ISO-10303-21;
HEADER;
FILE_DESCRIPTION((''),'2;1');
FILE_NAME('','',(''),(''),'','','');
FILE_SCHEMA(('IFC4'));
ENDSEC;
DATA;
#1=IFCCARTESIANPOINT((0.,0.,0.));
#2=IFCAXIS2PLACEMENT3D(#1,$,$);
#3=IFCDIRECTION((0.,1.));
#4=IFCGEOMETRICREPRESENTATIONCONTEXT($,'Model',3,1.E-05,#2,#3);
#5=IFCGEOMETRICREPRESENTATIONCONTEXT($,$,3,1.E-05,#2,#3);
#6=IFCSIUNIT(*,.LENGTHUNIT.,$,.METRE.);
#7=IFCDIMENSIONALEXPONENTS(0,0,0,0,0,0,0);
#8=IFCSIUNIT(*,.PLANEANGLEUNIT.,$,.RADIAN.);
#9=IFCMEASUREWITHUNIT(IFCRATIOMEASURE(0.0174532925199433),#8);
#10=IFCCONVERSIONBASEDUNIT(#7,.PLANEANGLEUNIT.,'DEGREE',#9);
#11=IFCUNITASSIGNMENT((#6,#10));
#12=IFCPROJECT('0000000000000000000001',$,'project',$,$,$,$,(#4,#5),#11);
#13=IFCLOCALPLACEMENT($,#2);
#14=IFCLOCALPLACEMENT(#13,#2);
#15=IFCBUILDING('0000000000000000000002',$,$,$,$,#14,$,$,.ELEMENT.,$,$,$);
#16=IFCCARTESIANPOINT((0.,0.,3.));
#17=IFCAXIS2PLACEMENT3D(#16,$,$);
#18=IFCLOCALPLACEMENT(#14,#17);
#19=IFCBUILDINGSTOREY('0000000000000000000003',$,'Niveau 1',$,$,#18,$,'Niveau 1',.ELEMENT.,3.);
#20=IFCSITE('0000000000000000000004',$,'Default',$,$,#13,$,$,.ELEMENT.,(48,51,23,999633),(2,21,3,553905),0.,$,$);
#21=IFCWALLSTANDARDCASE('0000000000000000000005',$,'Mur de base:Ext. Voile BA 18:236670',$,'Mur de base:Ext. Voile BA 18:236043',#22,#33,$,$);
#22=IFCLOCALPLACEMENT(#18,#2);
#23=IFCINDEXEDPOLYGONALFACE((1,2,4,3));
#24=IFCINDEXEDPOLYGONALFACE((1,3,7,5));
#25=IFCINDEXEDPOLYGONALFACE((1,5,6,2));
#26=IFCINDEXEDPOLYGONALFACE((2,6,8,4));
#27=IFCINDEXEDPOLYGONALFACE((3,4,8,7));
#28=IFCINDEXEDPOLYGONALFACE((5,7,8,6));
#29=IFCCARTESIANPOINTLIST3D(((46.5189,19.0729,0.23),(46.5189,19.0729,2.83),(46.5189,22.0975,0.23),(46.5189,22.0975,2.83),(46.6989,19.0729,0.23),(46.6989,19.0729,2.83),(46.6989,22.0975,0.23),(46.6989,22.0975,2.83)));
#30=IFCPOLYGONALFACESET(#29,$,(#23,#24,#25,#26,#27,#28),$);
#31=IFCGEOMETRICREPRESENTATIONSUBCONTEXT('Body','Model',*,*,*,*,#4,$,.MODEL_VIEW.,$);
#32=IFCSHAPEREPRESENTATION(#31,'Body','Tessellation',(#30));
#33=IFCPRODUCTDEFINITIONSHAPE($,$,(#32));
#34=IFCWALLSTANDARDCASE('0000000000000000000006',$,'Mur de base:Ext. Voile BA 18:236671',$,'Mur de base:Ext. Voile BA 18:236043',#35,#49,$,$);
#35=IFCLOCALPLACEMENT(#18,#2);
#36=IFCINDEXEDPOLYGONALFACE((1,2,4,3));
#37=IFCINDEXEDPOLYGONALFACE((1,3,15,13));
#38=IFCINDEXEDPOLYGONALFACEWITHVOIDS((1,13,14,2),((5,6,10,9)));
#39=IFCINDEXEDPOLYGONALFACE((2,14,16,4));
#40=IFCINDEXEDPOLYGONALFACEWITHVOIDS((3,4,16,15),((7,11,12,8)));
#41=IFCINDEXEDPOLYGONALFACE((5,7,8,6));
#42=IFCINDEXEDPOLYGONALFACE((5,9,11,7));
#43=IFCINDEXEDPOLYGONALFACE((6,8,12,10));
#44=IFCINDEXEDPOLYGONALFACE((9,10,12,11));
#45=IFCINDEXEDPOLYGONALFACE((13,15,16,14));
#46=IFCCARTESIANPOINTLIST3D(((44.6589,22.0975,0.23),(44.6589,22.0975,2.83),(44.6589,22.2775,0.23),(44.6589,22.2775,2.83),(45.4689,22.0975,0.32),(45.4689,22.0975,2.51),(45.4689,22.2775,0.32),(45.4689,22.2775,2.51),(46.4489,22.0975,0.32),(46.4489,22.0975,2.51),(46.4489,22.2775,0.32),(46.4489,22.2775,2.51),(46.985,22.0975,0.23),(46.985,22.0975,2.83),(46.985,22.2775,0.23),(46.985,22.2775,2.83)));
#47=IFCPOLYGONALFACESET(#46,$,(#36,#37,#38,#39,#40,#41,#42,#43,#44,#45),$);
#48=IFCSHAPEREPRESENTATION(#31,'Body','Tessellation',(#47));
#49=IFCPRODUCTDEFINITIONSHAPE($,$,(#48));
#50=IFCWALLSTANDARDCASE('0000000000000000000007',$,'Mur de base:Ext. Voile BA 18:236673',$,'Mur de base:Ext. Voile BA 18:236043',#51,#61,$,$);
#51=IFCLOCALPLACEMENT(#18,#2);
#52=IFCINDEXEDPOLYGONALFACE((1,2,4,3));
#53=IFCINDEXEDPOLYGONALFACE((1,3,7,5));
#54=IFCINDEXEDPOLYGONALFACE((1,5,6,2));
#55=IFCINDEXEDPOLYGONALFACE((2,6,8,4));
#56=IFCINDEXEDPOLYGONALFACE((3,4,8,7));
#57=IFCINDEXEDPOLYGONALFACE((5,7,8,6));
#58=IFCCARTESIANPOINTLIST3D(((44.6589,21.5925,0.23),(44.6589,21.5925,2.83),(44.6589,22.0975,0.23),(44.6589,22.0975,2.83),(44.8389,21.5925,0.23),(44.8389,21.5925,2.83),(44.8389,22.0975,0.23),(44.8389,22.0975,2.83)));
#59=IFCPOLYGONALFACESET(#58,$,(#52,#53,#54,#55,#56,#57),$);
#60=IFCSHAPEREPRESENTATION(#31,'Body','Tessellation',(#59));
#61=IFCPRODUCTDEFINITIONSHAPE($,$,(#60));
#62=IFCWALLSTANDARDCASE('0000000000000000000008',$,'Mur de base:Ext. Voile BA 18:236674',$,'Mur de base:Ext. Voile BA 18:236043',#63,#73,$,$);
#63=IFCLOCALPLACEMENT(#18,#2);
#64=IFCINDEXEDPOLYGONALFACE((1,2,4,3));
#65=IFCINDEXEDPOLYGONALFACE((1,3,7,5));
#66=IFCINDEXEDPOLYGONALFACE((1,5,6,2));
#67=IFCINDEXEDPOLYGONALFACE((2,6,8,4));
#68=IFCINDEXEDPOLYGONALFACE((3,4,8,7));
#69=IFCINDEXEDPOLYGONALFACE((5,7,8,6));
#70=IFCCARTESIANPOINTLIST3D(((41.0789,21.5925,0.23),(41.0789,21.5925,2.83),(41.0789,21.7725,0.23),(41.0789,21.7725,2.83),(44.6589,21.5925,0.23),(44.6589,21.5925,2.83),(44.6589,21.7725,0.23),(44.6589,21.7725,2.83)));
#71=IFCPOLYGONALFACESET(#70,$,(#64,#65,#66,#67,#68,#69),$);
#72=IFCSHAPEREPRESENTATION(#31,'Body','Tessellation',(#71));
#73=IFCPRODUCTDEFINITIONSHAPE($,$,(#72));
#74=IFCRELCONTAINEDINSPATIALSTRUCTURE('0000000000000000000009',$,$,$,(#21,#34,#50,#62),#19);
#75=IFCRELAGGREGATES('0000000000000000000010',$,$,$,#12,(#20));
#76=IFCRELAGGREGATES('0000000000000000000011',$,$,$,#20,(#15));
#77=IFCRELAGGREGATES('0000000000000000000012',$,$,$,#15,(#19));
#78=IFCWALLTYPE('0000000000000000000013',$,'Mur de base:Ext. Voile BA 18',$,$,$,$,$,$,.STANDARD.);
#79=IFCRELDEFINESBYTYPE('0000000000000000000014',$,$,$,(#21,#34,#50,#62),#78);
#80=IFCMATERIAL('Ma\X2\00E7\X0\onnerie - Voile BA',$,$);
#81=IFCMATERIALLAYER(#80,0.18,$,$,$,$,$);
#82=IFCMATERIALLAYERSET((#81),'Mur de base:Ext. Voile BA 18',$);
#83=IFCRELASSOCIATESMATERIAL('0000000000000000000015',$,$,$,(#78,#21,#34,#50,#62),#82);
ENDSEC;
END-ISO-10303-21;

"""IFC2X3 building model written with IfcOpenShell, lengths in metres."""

from ifc_helpers import new_model, entity, si_unit, converted_unit, direction, frame, frame_2d, origin, place, context, subcontext, project, spatial, rectangle, extrude, material, layer, layer_set, layer_usage, type_object, element, save


model = new_model("IFC2X3")

# Units and contexts
model_context = context("Model", 3, precision=1e-05, world=origin(), true_north=direction((0.0, 1.0)))
context_of_model = context(None, 3, precision=1e-05, world=origin(), true_north=direction((0.0, 1.0)))
body_context = subcontext(model_context, "Body", "Model", "MODEL_VIEW")
ifc_project = project(units=[si_unit("LENGTHUNIT", "METRE"), converted_unit("PLANEANGLEUNIT", "DEGREE", entity("IfcRatioMeasure", 0.0174532925199433), si_unit("PLANEANGLEUNIT", "RADIAN"), dimensions=[0, 0, 0, 0, 0, 0, 0])], contexts=[model_context, context_of_model])

# Site, building, storey
site_placement = place(None, origin())
site = spatial("IfcSite", under=ifc_project, at=site_placement, Name="Default", CompositionType="ELEMENT", RefLatitude=(48, 51, 23, 999633), RefLongitude=(2, 21, 3, 553905), RefElevation=0.0)
building_placement = place(site_placement, origin())
building = spatial("IfcBuilding", under=site, at=building_placement, CompositionType="ELEMENT")
storey_placement = place(building_placement, frame((0.0, 0.0, 3.0)))
storey = spatial("IfcBuildingStorey", under=building, at=storey_placement, Name="Niveau 1", LongName="Niveau 1", CompositionType="ELEMENT", Elevation=3.0)

# Shared definitions
ifc_material = material(Name="Maçonnerie - Voile BA")

# Shared definitions
ifc_layer_1 = layer(ifc_material, 0.18)
ifc_layer_set_1 = layer_set([ifc_layer_1], Name="Mur de base:Ext. Voile BA 18")
wall_type_1 = type_object("IfcWallType", Name="Mur de base:Ext. Voile BA 18", PredefinedType="STANDARD", material=ifc_layer_set_1)

# Wall
ifc_layer_usage_1 = layer_usage(ifc_layer_set_1, "AXIS2", "POSITIVE", -0.09)
wall_1_placement = place(storey_placement, frame((46.6089, 19.0729, 0.23), z_axis=(0.0, 0.0, 1.0), x_axis=(0.0, 1.0, 0.0)))
element("IfcWallStandardCase", 1, at=wall_1_placement, inside=storey, type_object=wall_type_1, material=ifc_layer_usage_1, Name="Mur de base:Ext. Voile BA 18:236670", ObjectType="Mur de base:Ext. Voile BA 18:236043", context=body_context, shape_type="SweptSolid", body=[
    extrude(rectangle(XDim=3.0246, YDim=0.18, at=frame_2d((1.5123, 0.0), x_axis=(-1.0, 0.0))), origin(), (0.0, 0.0, 1.0), 2.6),
])

# Wall, opening
ifc_layer_usage_2 = layer_usage(ifc_layer_set_1, "AXIS2", "POSITIVE", -0.09)
wall_2_placement = place(storey_placement, frame((46.985, 22.1875, 0.23), z_axis=(0.0, 0.0, 1.0), x_axis=(-1.0, 0.0, 0.0)))
wall_2 = element("IfcWallStandardCase", 2, at=wall_2_placement, inside=storey, type_object=wall_type_1, material=ifc_layer_usage_2, Name="Mur de base:Ext. Voile BA 18:236671", ObjectType="Mur de base:Ext. Voile BA 18:236043", context=body_context, shape_type="SweptSolid", body=[
    extrude(rectangle(XDim=2.3261, YDim=0.18, at=frame_2d((1.1631, 0.0), x_axis=(-1.0, 0.0))), origin(), (0.0, 0.0, 1.0), 2.6),
])
opening_1_placement = place(wall_2_placement, origin())
element("IfcOpeningElement", 3, at=opening_1_placement, cuts=wall_2, ObjectType="Opening", context=body_context, shape_type="SweptSolid", body=[
    extrude(rectangle(XDim=2.19, YDim=0.98, at=frame_2d((0.0, 0.0), x_axis=(1.0, 0.0))), frame((1.0261, -0.09, 1.185), z_axis=(0.0, 1.0, 0.0), x_axis=(0.0, 0.0, -1.0)), (0.0, 0.0, 1.0), 0.18),
])

# Walls
ifc_layer_usage_3 = layer_usage(ifc_layer_set_1, "AXIS2", "POSITIVE", -0.09)
wall_3_placement = place(storey_placement, frame((44.7489, 22.0975, 0.23), z_axis=(0.0, 0.0, 1.0), x_axis=(0.0, -1.0, 0.0)))
element("IfcWallStandardCase", 4, at=wall_3_placement, inside=storey, type_object=wall_type_1, material=ifc_layer_usage_3, Name="Mur de base:Ext. Voile BA 18:236673", ObjectType="Mur de base:Ext. Voile BA 18:236043", context=body_context, shape_type="SweptSolid", body=[
    extrude(rectangle(XDim=0.505, YDim=0.18, at=frame_2d((0.2525, 0.0), x_axis=(-1.0, 0.0))), origin(), (0.0, 0.0, 1.0), 2.6),
])
ifc_layer_usage_4 = layer_usage(ifc_layer_set_1, "AXIS2", "POSITIVE", -0.09)
wall_4_placement = place(storey_placement, frame((44.6589, 21.6825, 0.23), z_axis=(0.0, 0.0, 1.0), x_axis=(-1.0, 0.0, 0.0)))
element("IfcWallStandardCase", 5, at=wall_4_placement, inside=storey, type_object=wall_type_1, material=ifc_layer_usage_4, Name="Mur de base:Ext. Voile BA 18:236674", ObjectType="Mur de base:Ext. Voile BA 18:236043", context=body_context, shape_type="SweptSolid", body=[
    extrude(rectangle(XDim=3.58, YDim=0.18, at=frame_2d((1.79, 0.0), x_axis=(-1.0, 0.0))), origin(), (0.0, 0.0, 1.0), 2.6),
])

save(model, "model.ifc")
